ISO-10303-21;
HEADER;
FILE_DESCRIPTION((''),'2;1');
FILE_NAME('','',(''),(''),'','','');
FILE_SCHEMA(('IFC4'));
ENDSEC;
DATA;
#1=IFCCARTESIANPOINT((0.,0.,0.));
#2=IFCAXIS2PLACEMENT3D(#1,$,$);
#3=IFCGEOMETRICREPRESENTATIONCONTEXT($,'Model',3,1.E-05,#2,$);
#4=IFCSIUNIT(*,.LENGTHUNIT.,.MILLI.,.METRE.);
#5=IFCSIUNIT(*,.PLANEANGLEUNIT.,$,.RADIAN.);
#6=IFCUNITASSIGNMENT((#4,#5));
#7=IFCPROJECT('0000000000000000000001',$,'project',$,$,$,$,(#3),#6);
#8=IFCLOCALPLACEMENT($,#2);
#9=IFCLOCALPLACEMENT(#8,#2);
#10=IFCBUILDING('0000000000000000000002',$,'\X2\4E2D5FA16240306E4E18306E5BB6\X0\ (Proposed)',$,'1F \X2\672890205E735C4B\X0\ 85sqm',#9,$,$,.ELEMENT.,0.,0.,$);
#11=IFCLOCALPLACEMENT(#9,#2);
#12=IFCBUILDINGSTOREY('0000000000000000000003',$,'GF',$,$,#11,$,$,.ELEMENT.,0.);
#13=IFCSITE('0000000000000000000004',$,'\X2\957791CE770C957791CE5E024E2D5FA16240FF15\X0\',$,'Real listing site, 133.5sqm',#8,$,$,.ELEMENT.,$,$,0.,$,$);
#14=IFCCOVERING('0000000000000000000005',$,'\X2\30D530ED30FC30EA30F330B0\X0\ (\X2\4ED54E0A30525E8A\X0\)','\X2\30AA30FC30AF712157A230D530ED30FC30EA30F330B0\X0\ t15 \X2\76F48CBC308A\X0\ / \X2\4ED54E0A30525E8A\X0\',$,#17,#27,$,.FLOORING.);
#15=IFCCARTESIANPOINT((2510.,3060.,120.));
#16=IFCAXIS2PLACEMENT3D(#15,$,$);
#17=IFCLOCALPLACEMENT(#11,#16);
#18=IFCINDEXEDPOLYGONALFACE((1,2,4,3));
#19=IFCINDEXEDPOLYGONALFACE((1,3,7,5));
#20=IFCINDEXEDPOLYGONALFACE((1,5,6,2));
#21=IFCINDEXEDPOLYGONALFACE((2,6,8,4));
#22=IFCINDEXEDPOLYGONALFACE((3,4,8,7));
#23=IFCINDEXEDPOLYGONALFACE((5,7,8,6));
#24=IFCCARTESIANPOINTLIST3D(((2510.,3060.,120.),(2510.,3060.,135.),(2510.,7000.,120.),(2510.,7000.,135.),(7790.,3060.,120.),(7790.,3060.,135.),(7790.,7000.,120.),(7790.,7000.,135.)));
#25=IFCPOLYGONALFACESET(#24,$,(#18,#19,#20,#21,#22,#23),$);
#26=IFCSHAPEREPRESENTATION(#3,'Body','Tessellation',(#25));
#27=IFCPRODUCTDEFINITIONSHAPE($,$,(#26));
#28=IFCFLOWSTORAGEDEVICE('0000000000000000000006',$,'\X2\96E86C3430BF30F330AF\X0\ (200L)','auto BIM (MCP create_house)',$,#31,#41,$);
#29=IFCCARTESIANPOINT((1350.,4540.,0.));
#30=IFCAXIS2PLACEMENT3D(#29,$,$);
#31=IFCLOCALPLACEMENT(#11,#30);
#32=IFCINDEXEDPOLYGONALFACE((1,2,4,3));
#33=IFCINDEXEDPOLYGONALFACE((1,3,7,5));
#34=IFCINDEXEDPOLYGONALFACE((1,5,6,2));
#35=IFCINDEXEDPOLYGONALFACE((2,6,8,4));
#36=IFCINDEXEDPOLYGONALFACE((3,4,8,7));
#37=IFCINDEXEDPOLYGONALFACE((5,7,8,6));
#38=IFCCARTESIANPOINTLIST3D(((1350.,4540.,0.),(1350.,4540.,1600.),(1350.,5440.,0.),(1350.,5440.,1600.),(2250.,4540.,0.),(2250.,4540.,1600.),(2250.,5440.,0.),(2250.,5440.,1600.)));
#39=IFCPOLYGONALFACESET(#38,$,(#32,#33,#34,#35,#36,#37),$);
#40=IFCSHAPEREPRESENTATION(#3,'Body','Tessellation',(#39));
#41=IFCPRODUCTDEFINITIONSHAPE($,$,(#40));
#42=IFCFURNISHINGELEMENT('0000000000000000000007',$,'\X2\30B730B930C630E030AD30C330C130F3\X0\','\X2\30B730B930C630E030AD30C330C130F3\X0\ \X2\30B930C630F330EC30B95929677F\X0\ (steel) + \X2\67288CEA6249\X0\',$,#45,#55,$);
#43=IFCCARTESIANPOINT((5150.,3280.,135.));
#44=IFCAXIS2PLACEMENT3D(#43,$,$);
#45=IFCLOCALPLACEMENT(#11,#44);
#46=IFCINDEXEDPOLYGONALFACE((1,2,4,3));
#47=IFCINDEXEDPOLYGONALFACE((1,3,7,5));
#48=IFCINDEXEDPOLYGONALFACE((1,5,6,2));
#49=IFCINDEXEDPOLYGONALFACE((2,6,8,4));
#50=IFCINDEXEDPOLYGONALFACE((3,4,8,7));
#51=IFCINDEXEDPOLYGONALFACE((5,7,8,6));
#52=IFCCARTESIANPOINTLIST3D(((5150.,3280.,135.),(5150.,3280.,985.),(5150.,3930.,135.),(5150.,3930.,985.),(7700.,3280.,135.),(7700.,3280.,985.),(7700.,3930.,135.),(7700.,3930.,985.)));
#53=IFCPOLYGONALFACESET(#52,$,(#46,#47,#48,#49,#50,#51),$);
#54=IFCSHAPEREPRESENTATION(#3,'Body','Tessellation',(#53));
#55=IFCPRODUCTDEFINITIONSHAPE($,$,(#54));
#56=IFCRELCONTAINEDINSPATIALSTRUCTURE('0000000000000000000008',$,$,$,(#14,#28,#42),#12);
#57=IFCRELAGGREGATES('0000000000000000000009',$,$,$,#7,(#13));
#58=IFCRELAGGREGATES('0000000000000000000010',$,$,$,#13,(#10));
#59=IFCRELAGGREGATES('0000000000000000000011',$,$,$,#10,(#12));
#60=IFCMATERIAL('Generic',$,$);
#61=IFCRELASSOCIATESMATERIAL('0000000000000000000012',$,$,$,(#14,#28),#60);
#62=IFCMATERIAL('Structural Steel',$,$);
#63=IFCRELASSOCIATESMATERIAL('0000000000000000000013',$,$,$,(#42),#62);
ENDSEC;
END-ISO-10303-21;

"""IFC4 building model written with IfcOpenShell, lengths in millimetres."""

from ifc_helpers import new_model, si_unit, frame, frame_2d, origin, place, context, project, spatial, rectangle, extrude, material, element, save


model = new_model("IFC4")

# Units and contexts
model_context = context("Model", 3, precision=1e-05, world=origin())
ifc_project = project(units=[si_unit("LENGTHUNIT", "METRE", prefix="MILLI"), si_unit("PLANEANGLEUNIT", "RADIAN")], contexts=[model_context])

# Site, building, storey
site_placement = place(None, origin())
site = spatial("IfcSite", under=ifc_project, at=site_placement, Name="長野県長野市中御所５", ObjectType="Real listing site, 133.5sqm", CompositionType="ELEMENT", RefElevation=0.0)
building_placement = place(site_placement, origin())
building = spatial("IfcBuilding", under=site, at=building_placement, Name="中御所の丘の家 (Proposed)", ObjectType="1F 木造平屋 85sqm", CompositionType="ELEMENT", ElevationOfRefHeight=0.0, ElevationOfTerrain=0.0)
storey_placement = place(building_placement, origin())
storey = spatial("IfcBuildingStorey", under=building, at=storey_placement, Name="GF", CompositionType="ELEMENT", Elevation=0.0)

# Shared definitions
ifc_material_1 = material(Name="Generic")

# Covering
covering_placement = place(storey_placement, frame((2510.0, 3060.0, 120.0)))
element("IfcCovering", 1, at=covering_placement, inside=storey, material=ifc_material_1, Name="フローリング (仕上げ床)", Description="オーク無垢フローリング t15 直貼り / 仕上げ床", PredefinedType="FLOORING", context=model_context, shape_type="SweptSolid", body=[
    extrude(rectangle(XDim=5280.0, YDim=3940.0, at=frame_2d((2640.0, 1970.0))), frame((2510.0, 3060.0, 120.0)), (0.0, 0.0, 1.0), 15.0),
])

# Flow storage device
flow_storage_device_placement = place(storey_placement, frame((1350.0, 4540.0, 0.0)))
element("IfcFlowStorageDevice", 2, at=flow_storage_device_placement, inside=storey, material=ifc_material_1, Name="雨水タンク (200L)", Description="auto BIM (MCP create_house)", context=model_context, shape_type="SweptSolid", body=[
    extrude(rectangle(XDim=900.0, YDim=900.0, at=frame_2d((450.0, 450.0))), frame((1350.0, 4540.0, 0.0)), (0.0, 0.0, 1.0), 1600.0),
])

# Furnishing element
ifc_material_2 = material(Name="Structural Steel")
furnishing_placement = place(storey_placement, frame((5150.0, 3280.0, 135.0)))
element("IfcFurnishingElement", 3, at=furnishing_placement, inside=storey, material=ifc_material_2, Name="システムキッチン", Description="システムキッチン ステンレス天板 (steel) + 木質扉", context=model_context, shape_type="SweptSolid", body=[
    extrude(rectangle(XDim=2550.0, YDim=650.0, at=frame_2d((1275.0, 325.0))), frame((5150.0, 3280.0, 135.0)), (0.0, 0.0, 1.0), 850.0),
])

save(model, "model.ifc")
